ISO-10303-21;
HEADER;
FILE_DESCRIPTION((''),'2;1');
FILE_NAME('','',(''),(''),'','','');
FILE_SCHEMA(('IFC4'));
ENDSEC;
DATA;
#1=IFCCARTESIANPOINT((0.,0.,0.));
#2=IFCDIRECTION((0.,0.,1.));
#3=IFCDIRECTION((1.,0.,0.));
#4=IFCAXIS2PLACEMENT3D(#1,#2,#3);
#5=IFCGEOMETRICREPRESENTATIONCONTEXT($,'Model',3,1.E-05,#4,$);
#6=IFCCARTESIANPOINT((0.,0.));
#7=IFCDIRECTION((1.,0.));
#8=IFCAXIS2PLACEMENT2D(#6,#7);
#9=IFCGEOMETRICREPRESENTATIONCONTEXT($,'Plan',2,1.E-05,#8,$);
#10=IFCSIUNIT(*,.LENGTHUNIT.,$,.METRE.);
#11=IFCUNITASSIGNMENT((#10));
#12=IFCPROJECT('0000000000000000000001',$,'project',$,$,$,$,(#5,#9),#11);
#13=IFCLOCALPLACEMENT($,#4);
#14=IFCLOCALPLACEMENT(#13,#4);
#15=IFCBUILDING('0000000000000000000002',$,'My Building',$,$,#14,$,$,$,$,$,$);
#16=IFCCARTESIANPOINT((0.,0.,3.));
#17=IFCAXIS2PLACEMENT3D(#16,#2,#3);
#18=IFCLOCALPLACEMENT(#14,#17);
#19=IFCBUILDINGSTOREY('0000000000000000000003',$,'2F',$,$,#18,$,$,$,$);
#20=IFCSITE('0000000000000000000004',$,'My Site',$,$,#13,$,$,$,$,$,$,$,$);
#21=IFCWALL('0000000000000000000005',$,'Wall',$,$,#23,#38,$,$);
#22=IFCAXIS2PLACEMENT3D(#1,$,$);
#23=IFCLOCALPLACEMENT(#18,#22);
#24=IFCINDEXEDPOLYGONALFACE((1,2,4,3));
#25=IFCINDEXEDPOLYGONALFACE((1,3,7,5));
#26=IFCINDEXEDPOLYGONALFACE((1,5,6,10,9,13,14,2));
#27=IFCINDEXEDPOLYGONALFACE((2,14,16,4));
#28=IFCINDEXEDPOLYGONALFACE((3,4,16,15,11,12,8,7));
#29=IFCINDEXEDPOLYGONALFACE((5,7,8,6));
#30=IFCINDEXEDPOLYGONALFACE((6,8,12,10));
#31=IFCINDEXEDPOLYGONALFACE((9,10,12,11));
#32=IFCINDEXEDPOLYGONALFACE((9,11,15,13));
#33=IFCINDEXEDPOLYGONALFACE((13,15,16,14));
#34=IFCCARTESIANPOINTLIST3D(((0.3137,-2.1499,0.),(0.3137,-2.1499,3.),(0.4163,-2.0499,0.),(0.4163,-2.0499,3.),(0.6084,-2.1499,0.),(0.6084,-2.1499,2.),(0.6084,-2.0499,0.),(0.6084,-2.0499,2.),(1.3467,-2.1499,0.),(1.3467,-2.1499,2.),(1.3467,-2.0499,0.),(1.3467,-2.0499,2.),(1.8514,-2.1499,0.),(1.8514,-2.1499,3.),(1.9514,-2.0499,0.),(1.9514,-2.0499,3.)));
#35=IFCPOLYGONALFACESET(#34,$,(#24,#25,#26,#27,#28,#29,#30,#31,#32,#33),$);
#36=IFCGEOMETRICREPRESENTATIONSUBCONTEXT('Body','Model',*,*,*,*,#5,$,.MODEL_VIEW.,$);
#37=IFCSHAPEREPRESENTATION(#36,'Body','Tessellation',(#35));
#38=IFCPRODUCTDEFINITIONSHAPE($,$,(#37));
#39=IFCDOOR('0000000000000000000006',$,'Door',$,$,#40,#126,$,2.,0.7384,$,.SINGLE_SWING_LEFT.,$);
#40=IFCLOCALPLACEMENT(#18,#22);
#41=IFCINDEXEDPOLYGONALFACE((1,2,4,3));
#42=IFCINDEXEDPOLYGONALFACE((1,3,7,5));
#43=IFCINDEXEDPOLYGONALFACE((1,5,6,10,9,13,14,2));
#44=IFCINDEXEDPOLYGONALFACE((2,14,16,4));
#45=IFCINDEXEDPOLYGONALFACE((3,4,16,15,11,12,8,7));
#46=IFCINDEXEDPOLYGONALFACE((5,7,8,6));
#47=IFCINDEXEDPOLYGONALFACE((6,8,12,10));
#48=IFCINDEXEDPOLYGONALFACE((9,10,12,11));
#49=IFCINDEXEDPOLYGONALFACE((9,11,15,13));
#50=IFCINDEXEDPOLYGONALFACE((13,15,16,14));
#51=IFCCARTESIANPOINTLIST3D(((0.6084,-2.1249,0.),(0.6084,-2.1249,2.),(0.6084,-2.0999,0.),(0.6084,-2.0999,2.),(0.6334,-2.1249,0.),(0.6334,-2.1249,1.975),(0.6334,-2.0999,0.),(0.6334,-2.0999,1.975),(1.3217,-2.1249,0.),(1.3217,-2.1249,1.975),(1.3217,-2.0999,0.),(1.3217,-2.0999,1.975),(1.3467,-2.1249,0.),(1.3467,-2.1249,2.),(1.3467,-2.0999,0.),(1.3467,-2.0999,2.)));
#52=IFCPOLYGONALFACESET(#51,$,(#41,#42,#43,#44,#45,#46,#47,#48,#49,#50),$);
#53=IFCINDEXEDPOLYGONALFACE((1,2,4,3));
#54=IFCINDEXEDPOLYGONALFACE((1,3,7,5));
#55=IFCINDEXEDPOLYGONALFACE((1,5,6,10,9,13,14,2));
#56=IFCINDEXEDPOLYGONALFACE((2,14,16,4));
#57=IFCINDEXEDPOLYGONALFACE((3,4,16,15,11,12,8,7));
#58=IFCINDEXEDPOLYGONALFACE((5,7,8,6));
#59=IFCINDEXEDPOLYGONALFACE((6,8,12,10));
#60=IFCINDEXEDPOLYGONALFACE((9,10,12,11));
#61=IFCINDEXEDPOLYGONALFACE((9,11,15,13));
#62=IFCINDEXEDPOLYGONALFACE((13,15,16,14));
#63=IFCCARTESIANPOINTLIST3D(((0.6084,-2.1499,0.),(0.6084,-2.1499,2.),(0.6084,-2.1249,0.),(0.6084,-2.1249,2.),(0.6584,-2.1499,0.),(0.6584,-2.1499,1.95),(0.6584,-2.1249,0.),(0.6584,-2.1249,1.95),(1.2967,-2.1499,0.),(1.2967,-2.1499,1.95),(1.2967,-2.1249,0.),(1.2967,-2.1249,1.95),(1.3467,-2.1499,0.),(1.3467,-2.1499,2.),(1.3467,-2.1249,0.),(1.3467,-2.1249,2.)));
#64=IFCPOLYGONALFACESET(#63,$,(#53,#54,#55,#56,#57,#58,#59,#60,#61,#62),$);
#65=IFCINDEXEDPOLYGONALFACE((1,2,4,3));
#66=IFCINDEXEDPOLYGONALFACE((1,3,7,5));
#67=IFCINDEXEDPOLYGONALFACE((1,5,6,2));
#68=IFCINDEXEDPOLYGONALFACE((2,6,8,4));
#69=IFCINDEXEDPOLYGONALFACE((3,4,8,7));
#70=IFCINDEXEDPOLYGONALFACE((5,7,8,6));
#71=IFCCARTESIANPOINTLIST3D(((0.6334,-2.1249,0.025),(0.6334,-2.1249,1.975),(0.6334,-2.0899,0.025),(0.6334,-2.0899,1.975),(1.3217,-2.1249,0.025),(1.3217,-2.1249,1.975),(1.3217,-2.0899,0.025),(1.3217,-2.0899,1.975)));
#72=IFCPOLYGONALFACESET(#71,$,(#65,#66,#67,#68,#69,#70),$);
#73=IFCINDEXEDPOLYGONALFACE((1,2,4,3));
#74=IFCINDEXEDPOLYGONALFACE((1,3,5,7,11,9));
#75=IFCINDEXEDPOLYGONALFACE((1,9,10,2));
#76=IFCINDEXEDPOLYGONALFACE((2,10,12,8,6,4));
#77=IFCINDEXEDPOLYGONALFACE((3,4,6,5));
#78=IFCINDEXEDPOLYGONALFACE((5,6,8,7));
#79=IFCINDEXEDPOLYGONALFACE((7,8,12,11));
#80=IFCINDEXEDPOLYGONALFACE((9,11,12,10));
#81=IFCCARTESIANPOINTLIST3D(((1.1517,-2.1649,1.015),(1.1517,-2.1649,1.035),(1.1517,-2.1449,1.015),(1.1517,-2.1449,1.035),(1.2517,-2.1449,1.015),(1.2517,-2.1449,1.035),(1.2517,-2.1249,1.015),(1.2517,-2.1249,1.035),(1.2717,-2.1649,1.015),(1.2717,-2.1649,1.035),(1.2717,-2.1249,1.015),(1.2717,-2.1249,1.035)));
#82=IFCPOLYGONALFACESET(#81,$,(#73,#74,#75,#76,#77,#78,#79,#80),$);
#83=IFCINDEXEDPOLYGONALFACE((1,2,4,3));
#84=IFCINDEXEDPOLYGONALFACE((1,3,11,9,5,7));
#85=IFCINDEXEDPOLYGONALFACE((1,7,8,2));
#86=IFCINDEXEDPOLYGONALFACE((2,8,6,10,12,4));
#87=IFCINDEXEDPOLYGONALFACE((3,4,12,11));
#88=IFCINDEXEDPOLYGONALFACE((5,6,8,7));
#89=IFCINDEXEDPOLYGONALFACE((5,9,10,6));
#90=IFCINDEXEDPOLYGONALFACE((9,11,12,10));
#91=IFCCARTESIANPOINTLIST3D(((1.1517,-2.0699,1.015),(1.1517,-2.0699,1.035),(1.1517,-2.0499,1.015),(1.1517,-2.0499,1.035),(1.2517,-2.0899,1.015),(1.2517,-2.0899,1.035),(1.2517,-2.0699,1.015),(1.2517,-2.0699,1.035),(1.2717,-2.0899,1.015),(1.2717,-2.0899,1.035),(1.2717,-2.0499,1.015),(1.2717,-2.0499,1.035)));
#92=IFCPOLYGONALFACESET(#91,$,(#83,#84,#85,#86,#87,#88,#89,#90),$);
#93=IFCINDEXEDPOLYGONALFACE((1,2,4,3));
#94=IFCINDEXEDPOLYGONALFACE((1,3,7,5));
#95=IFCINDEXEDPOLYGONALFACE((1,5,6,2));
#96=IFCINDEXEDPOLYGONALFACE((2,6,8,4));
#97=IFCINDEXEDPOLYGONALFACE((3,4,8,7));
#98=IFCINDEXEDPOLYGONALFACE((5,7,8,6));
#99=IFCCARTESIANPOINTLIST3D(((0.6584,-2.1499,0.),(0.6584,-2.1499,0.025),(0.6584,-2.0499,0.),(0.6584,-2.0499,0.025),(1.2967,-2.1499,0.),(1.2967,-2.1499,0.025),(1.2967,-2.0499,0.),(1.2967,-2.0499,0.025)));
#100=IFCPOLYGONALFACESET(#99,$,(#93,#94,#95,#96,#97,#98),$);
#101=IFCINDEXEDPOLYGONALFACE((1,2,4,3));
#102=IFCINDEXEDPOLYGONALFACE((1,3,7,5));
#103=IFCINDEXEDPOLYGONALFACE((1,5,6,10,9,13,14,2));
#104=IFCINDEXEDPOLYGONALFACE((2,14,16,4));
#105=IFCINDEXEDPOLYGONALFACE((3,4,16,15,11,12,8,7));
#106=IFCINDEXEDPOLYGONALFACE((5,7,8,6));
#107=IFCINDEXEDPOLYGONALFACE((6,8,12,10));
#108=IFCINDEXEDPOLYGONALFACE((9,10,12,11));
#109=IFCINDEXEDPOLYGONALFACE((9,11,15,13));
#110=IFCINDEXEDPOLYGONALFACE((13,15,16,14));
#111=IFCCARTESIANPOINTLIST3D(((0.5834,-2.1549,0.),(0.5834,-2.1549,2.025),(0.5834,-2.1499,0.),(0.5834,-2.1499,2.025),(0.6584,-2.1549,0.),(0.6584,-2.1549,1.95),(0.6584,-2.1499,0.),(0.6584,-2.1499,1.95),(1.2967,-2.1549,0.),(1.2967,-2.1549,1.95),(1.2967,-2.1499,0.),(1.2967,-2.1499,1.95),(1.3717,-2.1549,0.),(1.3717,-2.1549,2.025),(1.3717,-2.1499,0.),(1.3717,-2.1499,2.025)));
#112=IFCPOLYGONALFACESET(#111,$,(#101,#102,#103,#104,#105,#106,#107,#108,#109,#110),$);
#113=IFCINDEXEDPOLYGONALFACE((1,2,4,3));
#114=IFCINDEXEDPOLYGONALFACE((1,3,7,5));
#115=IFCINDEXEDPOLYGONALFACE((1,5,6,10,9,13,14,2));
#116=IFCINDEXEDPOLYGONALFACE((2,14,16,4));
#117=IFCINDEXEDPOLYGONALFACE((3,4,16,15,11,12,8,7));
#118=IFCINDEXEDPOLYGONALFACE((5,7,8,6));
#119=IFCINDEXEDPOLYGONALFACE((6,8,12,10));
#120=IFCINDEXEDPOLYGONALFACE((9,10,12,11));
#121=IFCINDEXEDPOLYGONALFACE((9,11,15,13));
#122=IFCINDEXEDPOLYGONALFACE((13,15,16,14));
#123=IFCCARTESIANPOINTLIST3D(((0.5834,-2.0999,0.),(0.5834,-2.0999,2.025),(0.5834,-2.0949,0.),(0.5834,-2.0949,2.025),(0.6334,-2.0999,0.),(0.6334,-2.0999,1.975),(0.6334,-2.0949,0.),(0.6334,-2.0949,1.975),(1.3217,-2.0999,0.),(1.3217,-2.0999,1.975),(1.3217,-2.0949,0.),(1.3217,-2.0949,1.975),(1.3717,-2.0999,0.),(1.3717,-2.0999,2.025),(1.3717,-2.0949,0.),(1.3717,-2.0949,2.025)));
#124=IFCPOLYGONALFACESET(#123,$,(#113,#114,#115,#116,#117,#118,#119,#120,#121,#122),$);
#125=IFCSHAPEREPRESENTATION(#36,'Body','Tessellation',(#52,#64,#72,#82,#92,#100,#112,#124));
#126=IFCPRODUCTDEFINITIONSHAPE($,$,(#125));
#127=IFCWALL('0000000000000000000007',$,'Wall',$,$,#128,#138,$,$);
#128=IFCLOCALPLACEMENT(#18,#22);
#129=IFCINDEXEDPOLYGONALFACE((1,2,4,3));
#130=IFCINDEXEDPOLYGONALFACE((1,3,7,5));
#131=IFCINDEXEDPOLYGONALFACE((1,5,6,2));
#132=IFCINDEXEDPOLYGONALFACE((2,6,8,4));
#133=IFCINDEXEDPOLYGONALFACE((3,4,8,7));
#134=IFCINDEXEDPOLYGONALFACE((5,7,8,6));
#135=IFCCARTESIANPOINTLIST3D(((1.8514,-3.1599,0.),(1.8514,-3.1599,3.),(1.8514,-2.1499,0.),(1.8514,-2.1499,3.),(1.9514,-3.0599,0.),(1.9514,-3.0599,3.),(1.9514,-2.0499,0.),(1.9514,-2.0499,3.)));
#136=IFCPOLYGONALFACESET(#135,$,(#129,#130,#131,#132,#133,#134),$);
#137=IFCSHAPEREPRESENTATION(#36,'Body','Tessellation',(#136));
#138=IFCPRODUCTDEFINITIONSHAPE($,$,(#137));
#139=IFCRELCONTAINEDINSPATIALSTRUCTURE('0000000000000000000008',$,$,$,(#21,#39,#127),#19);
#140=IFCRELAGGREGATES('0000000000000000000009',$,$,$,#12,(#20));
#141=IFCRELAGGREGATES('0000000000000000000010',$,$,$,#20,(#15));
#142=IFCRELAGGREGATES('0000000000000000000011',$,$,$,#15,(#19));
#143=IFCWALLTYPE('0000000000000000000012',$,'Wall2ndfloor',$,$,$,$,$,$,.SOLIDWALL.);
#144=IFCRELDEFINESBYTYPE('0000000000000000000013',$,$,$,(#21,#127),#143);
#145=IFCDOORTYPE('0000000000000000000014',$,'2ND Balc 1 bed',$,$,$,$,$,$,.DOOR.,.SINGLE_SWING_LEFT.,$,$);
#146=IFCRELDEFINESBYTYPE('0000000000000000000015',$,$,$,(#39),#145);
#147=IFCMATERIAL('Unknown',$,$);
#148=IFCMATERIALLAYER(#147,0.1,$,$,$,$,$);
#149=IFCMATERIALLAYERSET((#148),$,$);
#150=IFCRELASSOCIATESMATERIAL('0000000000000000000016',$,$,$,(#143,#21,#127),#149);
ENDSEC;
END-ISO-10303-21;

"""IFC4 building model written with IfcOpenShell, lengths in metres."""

from ifc_helpers import new_model, entity, si_unit, frame, origin_with_axes, origin_2d_with_axis, place, context, subcontext, project, spatial, line, indexed_curve, outline, extrude, shape, source, transform, mapped, material, layer, layer_set, layer_usage, type_object, type_shapes, element, fill, save


model = new_model("IFC4")

# Units and contexts
model_context = context("Model", 3, precision=1e-05, world=origin_with_axes())
plan_context = context("Plan", 2, precision=1e-05, world=origin_2d_with_axis())
body_context_1 = subcontext(model_context, "Body", "Model", "MODEL_VIEW")
body_context_2 = subcontext(plan_context, "Body", "Plan", "PLAN_VIEW")
ifc_project = project(units=[si_unit("LENGTHUNIT", "METRE")], contexts=[model_context, plan_context])

# Site, building, storey
site_placement = place(None, origin_with_axes())
site = spatial("IfcSite", under=ifc_project, at=site_placement, Name="My Site")
building_placement = place(site_placement, origin_with_axes())
building = spatial("IfcBuilding", under=site, at=building_placement, Name="My Building")
storey_placement = place(building_placement, frame((0.0, 0.0, 3.0), z_axis=(0.0, 0.0, 1.0), x_axis=(1.0, 0.0, 0.0)))
storey = spatial("IfcBuildingStorey", under=building, at=storey_placement, Name="2F")

# Shared definitions
ifc_material = material(Name="Unknown")

# Shared definitions
ifc_layer_1 = layer(ifc_material, 0.1)
ifc_layer_set_1 = layer_set([ifc_layer_1])
wall_type = type_object("IfcWallType", Name="Wall2ndfloor", PredefinedType="SOLIDWALL", material=ifc_layer_set_1)

# Wall, opening, door
ifc_layer_usage_1 = layer_usage(ifc_layer_set_1, "AXIS2", "POSITIVE", 0.0)
wall_1_placement = place(storey_placement, frame((1.8514, -2.0499, 0.0), z_axis=(0.0, 0.0, 1.0), x_axis=(-1.0, 0.0, 0.0)))
wall_1 = element("IfcWall", 1, at=wall_1_placement, inside=storey, type_object=wall_type, material=ifc_layer_usage_1, Name="Wall", context=body_context_1, shape_type="SweptSolid", body=[
    extrude(outline(indexed_curve([(-0.1, 0.0), (0.0, 0.1), (1.5377, 0.1), (1.435, 0.0)], segments=[line(1, 2, 3, 4, 1)])), origin_with_axes(), (0.0, 0.0, 1.0), 3.0),
])
shared_shape_1 = source(origin_with_axes(), body_context_1, "Body", "SweptSolid", [
    extrude(outline(indexed_curve([(0.0, 0.0), (0.7384, 0.0), (0.7384, 2.0), (0.0, 2.0)], segments=[line(1, 2, 3, 4, 1)])), frame((0.0, -0.6, 0.0), z_axis=(0.0, -1.0, 0.0), x_axis=(1.0, 0.0, 0.0)), (0.0, 0.0, -1.0), 1.2),
])
opening_1_placement = place(wall_1_placement, frame((1.243, 0.1, 0.0), z_axis=(0.0, 0.0, 1.0), x_axis=(-1.0, 0.000001, 0.0)))
opening_1 = element("IfcOpeningElement", 2, at=opening_1_placement, cuts=wall_1, PredefinedType="OPENING", context=body_context_1, shape_type="MappedRepresentation", body=[
    mapped(shared_shape_1, transform((0.0, 0.0, 0.0), x_axis=(1.0, 0.0, 0.0), y_axis=(0.0, 1.0, 0.0), z_axis=(0.0, 0.0, 1.0), scale=1.0)),
])
door_type_1 = type_object("IfcDoorType", Name="2ND Balc 1 bed", OperationType="SINGLE_SWING_LEFT", PredefinedType="DOOR")
shared_shape_2 = source(origin_with_axes(), body_context_1, "Body", "SweptSolid", [
    extrude(outline(indexed_curve([(0.0, 0.0), (0.0, 2.0), (0.7384, 2.0), (0.7384, 0.0), (0.7134, 0.0), (0.7134, 1.975), (0.025, 1.975), (0.025, 0.0)], segments=[line(1, 2, 3, 4, 5, 6, 7, 8, 1)])), frame((0.0, 0.025, 0.0), z_axis=(0.0, -1.0, 0.0), x_axis=(1.0, 0.0, 0.0)), (0.0, 0.0, -1.0), 0.025),
    extrude(outline(indexed_curve([(0.0, 0.0), (0.0, 2.0), (0.7384, 2.0), (0.7384, 0.0), (0.6884, 0.0), (0.6884, 1.95), (0.05, 1.95), (0.05, 0.0)], segments=[line(1, 2, 3, 4, 5, 6, 7, 8, 1)])), frame((0.0, 0.0, 0.0), z_axis=(0.0, -1.0, 0.0), x_axis=(1.0, 0.0, 0.0)), (0.0, 0.0, -1.0), 0.025),
    extrude(outline(indexed_curve([(0.0, 0.0), (0.6884, 0.0), (0.6884, 0.035), (0.0, 0.035)], segments=[line(1, 2, 3, 4, 1)])), frame((0.025, 0.025, 0.025), z_axis=(0.0, 0.0, 1.0), x_axis=(1.0, 0.0, 0.0)), (0.0, 0.0, 1.0), 1.95),
    extrude(outline(indexed_curve([(0.0, 0.0), (0.0, -0.04), (-0.12, -0.04), (-0.12, -0.02), (-0.02, -0.02), (-0.02, 0.0)], segments=[line(1, 2, 3, 4, 5, 6, 1)])), frame((0.6634, 0.025, 1.015), z_axis=(0.0, 0.0, 1.0), x_axis=(1.0, 0.0, 0.0)), (0.0, 0.0, 1.0), 0.02),
    extrude(outline(indexed_curve([(0.0, 0.0), (0.0, 0.04), (-0.12, 0.04), (-0.12, 0.02), (-0.02, 0.02), (-0.02, 0.0)], segments=[line(1, 2, 3, 4, 5, 6, 1)])), frame((0.6634, 0.06, 1.015), z_axis=(0.0, 0.0, 1.0), x_axis=(1.0, 0.0, 0.0)), (0.0, 0.0, 1.0), 0.02),
    extrude(outline(indexed_curve([(0.0, 0.0), (0.6384, 0.0), (0.6384, 0.1), (0.0, 0.1)], segments=[line(1, 2, 3, 4, 1)])), frame((0.05, 0.0, 0.0), z_axis=(0.0, 0.0, 1.0), x_axis=(1.0, 0.0, 0.0)), (0.0, 0.0, 1.0), 0.025),
    extrude(outline(indexed_curve([(0.0, 0.0), (0.0, 2.025), (0.7884, 2.025), (0.7884, 0.0), (0.7134, 0.0), (0.7134, 1.95), (0.075, 1.95), (0.075, 0.0)], segments=[line(1, 2, 3, 4, 5, 6, 7, 8, 1)])), frame((-0.025, -0.005, 0.0), z_axis=(0.0, -1.0, 0.0), x_axis=(1.0, 0.0, 0.0)), (0.0, 0.0, -1.0), 0.005),
    extrude(outline(indexed_curve([(0.0, 0.0), (0.0, 2.025), (0.7884, 2.025), (0.7884, 0.0), (0.7384, 0.0), (0.7384, 1.975), (0.05, 1.975), (0.05, 0.0)], segments=[line(1, 2, 3, 4, 5, 6, 7, 8, 1)])), frame((-0.025, 0.05, 0.0), z_axis=(0.0, -1.0, 0.0), x_axis=(1.0, 0.0, 0.0)), (0.0, 0.0, -1.0), 0.005),
])
shared_shape_3 = source(origin_with_axes(), body_context_2, "Body", "Curve2D", [
    entity("IfcIndexedPolyCurve", entity("IfcCartesianPointList2D", [[0.0, 0.0], [0.0, 0.05], [0.025, 0.05], [0.025, 0.025], [0.05, 0.025], [0.05, 0.0]]), [entity("IfcLineIndex", [1, 2, 3, 4, 5, 6, 1])]),
    entity("IfcIndexedPolyCurve", entity("IfcCartesianPointList2D", [[0.7384, 0.0], [0.7384, 0.05], [0.7134, 0.05], [0.7134, 0.025], [0.6884, 0.025], [0.6884, 0.0]]), [entity("IfcLineIndex", [1, 2, 3, 4, 5, 6, 1])]),
    entity("IfcTrimmedCurve", entity("IfcEllipse", entity("IfcAxis2Placement2D", entity("IfcCartesianPoint", [0.06, 0.05]), entity("IfcDirection", [1.0, 0.0])), 0.6534, 0.6884), [entity("IfcCartesianPoint", [0.7134, 0.05])], [entity("IfcCartesianPoint", [0.06, 0.7384])], True, "CARTESIAN"),
    entity("IfcIndexedPolyCurve", entity("IfcCartesianPointList2D", [[0.025, 0.05], [0.06, 0.05], [0.06, 0.7384], [0.025, 0.7384]]), [entity("IfcLineIndex", [1, 2, 3, 4, 1])]),
])
type_shapes(door_type_1, [shared_shape_2, shared_shape_3])
door_1_placement = place(opening_1_placement, frame((0.0, 0.0, 0.0), z_axis=(0.0, 0.0, 1.0), x_axis=(1.0, 0.0, 0.0)))
door_1 = element("IfcDoor", 3, at=door_1_placement, inside=storey, type_object=door_type_1, Name="Door", OperationType="SINGLE_SWING_LEFT", OverallHeight=2.0, OverallWidth=0.7384, shapes=[
    shape(body_context_1, "Body", "MappedRepresentation", [mapped(shared_shape_2, transform((0.0, 0.0, 0.0), x_axis=(1.0, 0.0, 0.0), y_axis=(0.0, 1.0, 0.0), z_axis=(0.0, 0.0, 1.0), scale=1.0))]),
    shape(body_context_2, "Body", "MappedRepresentation", [mapped(shared_shape_3, transform((0.0, 0.0, 0.0), x_axis=(1.0, 0.0, 0.0), y_axis=(0.0, 1.0, 0.0), z_axis=(0.0, 0.0, 1.0), scale=1.0))]),
])
fill(opening_1, door_1)

# Wall
ifc_layer_usage_2 = layer_usage(ifc_layer_set_1, "AXIS2", "POSITIVE", 0.0)
wall_2_placement = place(storey_placement, frame((1.8514, -2.0499, 0.0), z_axis=(0.0, 0.0, 1.0), x_axis=(0.0, -1.0, 0.0)))
element("IfcWall", 4, at=wall_2_placement, inside=storey, type_object=wall_type, material=ifc_layer_usage_2, Name="Wall", context=body_context_1, shape_type="SweptSolid", body=[
    extrude(outline(indexed_curve([(0.1, 0.0), (0.0, 0.1), (1.01, 0.1), (1.11, 0.0)], segments=[line(1, 2, 3, 4, 1)])), origin_with_axes(), (0.0, 0.0, 1.0), 3.0),
])

save(model, "model.ifc")
